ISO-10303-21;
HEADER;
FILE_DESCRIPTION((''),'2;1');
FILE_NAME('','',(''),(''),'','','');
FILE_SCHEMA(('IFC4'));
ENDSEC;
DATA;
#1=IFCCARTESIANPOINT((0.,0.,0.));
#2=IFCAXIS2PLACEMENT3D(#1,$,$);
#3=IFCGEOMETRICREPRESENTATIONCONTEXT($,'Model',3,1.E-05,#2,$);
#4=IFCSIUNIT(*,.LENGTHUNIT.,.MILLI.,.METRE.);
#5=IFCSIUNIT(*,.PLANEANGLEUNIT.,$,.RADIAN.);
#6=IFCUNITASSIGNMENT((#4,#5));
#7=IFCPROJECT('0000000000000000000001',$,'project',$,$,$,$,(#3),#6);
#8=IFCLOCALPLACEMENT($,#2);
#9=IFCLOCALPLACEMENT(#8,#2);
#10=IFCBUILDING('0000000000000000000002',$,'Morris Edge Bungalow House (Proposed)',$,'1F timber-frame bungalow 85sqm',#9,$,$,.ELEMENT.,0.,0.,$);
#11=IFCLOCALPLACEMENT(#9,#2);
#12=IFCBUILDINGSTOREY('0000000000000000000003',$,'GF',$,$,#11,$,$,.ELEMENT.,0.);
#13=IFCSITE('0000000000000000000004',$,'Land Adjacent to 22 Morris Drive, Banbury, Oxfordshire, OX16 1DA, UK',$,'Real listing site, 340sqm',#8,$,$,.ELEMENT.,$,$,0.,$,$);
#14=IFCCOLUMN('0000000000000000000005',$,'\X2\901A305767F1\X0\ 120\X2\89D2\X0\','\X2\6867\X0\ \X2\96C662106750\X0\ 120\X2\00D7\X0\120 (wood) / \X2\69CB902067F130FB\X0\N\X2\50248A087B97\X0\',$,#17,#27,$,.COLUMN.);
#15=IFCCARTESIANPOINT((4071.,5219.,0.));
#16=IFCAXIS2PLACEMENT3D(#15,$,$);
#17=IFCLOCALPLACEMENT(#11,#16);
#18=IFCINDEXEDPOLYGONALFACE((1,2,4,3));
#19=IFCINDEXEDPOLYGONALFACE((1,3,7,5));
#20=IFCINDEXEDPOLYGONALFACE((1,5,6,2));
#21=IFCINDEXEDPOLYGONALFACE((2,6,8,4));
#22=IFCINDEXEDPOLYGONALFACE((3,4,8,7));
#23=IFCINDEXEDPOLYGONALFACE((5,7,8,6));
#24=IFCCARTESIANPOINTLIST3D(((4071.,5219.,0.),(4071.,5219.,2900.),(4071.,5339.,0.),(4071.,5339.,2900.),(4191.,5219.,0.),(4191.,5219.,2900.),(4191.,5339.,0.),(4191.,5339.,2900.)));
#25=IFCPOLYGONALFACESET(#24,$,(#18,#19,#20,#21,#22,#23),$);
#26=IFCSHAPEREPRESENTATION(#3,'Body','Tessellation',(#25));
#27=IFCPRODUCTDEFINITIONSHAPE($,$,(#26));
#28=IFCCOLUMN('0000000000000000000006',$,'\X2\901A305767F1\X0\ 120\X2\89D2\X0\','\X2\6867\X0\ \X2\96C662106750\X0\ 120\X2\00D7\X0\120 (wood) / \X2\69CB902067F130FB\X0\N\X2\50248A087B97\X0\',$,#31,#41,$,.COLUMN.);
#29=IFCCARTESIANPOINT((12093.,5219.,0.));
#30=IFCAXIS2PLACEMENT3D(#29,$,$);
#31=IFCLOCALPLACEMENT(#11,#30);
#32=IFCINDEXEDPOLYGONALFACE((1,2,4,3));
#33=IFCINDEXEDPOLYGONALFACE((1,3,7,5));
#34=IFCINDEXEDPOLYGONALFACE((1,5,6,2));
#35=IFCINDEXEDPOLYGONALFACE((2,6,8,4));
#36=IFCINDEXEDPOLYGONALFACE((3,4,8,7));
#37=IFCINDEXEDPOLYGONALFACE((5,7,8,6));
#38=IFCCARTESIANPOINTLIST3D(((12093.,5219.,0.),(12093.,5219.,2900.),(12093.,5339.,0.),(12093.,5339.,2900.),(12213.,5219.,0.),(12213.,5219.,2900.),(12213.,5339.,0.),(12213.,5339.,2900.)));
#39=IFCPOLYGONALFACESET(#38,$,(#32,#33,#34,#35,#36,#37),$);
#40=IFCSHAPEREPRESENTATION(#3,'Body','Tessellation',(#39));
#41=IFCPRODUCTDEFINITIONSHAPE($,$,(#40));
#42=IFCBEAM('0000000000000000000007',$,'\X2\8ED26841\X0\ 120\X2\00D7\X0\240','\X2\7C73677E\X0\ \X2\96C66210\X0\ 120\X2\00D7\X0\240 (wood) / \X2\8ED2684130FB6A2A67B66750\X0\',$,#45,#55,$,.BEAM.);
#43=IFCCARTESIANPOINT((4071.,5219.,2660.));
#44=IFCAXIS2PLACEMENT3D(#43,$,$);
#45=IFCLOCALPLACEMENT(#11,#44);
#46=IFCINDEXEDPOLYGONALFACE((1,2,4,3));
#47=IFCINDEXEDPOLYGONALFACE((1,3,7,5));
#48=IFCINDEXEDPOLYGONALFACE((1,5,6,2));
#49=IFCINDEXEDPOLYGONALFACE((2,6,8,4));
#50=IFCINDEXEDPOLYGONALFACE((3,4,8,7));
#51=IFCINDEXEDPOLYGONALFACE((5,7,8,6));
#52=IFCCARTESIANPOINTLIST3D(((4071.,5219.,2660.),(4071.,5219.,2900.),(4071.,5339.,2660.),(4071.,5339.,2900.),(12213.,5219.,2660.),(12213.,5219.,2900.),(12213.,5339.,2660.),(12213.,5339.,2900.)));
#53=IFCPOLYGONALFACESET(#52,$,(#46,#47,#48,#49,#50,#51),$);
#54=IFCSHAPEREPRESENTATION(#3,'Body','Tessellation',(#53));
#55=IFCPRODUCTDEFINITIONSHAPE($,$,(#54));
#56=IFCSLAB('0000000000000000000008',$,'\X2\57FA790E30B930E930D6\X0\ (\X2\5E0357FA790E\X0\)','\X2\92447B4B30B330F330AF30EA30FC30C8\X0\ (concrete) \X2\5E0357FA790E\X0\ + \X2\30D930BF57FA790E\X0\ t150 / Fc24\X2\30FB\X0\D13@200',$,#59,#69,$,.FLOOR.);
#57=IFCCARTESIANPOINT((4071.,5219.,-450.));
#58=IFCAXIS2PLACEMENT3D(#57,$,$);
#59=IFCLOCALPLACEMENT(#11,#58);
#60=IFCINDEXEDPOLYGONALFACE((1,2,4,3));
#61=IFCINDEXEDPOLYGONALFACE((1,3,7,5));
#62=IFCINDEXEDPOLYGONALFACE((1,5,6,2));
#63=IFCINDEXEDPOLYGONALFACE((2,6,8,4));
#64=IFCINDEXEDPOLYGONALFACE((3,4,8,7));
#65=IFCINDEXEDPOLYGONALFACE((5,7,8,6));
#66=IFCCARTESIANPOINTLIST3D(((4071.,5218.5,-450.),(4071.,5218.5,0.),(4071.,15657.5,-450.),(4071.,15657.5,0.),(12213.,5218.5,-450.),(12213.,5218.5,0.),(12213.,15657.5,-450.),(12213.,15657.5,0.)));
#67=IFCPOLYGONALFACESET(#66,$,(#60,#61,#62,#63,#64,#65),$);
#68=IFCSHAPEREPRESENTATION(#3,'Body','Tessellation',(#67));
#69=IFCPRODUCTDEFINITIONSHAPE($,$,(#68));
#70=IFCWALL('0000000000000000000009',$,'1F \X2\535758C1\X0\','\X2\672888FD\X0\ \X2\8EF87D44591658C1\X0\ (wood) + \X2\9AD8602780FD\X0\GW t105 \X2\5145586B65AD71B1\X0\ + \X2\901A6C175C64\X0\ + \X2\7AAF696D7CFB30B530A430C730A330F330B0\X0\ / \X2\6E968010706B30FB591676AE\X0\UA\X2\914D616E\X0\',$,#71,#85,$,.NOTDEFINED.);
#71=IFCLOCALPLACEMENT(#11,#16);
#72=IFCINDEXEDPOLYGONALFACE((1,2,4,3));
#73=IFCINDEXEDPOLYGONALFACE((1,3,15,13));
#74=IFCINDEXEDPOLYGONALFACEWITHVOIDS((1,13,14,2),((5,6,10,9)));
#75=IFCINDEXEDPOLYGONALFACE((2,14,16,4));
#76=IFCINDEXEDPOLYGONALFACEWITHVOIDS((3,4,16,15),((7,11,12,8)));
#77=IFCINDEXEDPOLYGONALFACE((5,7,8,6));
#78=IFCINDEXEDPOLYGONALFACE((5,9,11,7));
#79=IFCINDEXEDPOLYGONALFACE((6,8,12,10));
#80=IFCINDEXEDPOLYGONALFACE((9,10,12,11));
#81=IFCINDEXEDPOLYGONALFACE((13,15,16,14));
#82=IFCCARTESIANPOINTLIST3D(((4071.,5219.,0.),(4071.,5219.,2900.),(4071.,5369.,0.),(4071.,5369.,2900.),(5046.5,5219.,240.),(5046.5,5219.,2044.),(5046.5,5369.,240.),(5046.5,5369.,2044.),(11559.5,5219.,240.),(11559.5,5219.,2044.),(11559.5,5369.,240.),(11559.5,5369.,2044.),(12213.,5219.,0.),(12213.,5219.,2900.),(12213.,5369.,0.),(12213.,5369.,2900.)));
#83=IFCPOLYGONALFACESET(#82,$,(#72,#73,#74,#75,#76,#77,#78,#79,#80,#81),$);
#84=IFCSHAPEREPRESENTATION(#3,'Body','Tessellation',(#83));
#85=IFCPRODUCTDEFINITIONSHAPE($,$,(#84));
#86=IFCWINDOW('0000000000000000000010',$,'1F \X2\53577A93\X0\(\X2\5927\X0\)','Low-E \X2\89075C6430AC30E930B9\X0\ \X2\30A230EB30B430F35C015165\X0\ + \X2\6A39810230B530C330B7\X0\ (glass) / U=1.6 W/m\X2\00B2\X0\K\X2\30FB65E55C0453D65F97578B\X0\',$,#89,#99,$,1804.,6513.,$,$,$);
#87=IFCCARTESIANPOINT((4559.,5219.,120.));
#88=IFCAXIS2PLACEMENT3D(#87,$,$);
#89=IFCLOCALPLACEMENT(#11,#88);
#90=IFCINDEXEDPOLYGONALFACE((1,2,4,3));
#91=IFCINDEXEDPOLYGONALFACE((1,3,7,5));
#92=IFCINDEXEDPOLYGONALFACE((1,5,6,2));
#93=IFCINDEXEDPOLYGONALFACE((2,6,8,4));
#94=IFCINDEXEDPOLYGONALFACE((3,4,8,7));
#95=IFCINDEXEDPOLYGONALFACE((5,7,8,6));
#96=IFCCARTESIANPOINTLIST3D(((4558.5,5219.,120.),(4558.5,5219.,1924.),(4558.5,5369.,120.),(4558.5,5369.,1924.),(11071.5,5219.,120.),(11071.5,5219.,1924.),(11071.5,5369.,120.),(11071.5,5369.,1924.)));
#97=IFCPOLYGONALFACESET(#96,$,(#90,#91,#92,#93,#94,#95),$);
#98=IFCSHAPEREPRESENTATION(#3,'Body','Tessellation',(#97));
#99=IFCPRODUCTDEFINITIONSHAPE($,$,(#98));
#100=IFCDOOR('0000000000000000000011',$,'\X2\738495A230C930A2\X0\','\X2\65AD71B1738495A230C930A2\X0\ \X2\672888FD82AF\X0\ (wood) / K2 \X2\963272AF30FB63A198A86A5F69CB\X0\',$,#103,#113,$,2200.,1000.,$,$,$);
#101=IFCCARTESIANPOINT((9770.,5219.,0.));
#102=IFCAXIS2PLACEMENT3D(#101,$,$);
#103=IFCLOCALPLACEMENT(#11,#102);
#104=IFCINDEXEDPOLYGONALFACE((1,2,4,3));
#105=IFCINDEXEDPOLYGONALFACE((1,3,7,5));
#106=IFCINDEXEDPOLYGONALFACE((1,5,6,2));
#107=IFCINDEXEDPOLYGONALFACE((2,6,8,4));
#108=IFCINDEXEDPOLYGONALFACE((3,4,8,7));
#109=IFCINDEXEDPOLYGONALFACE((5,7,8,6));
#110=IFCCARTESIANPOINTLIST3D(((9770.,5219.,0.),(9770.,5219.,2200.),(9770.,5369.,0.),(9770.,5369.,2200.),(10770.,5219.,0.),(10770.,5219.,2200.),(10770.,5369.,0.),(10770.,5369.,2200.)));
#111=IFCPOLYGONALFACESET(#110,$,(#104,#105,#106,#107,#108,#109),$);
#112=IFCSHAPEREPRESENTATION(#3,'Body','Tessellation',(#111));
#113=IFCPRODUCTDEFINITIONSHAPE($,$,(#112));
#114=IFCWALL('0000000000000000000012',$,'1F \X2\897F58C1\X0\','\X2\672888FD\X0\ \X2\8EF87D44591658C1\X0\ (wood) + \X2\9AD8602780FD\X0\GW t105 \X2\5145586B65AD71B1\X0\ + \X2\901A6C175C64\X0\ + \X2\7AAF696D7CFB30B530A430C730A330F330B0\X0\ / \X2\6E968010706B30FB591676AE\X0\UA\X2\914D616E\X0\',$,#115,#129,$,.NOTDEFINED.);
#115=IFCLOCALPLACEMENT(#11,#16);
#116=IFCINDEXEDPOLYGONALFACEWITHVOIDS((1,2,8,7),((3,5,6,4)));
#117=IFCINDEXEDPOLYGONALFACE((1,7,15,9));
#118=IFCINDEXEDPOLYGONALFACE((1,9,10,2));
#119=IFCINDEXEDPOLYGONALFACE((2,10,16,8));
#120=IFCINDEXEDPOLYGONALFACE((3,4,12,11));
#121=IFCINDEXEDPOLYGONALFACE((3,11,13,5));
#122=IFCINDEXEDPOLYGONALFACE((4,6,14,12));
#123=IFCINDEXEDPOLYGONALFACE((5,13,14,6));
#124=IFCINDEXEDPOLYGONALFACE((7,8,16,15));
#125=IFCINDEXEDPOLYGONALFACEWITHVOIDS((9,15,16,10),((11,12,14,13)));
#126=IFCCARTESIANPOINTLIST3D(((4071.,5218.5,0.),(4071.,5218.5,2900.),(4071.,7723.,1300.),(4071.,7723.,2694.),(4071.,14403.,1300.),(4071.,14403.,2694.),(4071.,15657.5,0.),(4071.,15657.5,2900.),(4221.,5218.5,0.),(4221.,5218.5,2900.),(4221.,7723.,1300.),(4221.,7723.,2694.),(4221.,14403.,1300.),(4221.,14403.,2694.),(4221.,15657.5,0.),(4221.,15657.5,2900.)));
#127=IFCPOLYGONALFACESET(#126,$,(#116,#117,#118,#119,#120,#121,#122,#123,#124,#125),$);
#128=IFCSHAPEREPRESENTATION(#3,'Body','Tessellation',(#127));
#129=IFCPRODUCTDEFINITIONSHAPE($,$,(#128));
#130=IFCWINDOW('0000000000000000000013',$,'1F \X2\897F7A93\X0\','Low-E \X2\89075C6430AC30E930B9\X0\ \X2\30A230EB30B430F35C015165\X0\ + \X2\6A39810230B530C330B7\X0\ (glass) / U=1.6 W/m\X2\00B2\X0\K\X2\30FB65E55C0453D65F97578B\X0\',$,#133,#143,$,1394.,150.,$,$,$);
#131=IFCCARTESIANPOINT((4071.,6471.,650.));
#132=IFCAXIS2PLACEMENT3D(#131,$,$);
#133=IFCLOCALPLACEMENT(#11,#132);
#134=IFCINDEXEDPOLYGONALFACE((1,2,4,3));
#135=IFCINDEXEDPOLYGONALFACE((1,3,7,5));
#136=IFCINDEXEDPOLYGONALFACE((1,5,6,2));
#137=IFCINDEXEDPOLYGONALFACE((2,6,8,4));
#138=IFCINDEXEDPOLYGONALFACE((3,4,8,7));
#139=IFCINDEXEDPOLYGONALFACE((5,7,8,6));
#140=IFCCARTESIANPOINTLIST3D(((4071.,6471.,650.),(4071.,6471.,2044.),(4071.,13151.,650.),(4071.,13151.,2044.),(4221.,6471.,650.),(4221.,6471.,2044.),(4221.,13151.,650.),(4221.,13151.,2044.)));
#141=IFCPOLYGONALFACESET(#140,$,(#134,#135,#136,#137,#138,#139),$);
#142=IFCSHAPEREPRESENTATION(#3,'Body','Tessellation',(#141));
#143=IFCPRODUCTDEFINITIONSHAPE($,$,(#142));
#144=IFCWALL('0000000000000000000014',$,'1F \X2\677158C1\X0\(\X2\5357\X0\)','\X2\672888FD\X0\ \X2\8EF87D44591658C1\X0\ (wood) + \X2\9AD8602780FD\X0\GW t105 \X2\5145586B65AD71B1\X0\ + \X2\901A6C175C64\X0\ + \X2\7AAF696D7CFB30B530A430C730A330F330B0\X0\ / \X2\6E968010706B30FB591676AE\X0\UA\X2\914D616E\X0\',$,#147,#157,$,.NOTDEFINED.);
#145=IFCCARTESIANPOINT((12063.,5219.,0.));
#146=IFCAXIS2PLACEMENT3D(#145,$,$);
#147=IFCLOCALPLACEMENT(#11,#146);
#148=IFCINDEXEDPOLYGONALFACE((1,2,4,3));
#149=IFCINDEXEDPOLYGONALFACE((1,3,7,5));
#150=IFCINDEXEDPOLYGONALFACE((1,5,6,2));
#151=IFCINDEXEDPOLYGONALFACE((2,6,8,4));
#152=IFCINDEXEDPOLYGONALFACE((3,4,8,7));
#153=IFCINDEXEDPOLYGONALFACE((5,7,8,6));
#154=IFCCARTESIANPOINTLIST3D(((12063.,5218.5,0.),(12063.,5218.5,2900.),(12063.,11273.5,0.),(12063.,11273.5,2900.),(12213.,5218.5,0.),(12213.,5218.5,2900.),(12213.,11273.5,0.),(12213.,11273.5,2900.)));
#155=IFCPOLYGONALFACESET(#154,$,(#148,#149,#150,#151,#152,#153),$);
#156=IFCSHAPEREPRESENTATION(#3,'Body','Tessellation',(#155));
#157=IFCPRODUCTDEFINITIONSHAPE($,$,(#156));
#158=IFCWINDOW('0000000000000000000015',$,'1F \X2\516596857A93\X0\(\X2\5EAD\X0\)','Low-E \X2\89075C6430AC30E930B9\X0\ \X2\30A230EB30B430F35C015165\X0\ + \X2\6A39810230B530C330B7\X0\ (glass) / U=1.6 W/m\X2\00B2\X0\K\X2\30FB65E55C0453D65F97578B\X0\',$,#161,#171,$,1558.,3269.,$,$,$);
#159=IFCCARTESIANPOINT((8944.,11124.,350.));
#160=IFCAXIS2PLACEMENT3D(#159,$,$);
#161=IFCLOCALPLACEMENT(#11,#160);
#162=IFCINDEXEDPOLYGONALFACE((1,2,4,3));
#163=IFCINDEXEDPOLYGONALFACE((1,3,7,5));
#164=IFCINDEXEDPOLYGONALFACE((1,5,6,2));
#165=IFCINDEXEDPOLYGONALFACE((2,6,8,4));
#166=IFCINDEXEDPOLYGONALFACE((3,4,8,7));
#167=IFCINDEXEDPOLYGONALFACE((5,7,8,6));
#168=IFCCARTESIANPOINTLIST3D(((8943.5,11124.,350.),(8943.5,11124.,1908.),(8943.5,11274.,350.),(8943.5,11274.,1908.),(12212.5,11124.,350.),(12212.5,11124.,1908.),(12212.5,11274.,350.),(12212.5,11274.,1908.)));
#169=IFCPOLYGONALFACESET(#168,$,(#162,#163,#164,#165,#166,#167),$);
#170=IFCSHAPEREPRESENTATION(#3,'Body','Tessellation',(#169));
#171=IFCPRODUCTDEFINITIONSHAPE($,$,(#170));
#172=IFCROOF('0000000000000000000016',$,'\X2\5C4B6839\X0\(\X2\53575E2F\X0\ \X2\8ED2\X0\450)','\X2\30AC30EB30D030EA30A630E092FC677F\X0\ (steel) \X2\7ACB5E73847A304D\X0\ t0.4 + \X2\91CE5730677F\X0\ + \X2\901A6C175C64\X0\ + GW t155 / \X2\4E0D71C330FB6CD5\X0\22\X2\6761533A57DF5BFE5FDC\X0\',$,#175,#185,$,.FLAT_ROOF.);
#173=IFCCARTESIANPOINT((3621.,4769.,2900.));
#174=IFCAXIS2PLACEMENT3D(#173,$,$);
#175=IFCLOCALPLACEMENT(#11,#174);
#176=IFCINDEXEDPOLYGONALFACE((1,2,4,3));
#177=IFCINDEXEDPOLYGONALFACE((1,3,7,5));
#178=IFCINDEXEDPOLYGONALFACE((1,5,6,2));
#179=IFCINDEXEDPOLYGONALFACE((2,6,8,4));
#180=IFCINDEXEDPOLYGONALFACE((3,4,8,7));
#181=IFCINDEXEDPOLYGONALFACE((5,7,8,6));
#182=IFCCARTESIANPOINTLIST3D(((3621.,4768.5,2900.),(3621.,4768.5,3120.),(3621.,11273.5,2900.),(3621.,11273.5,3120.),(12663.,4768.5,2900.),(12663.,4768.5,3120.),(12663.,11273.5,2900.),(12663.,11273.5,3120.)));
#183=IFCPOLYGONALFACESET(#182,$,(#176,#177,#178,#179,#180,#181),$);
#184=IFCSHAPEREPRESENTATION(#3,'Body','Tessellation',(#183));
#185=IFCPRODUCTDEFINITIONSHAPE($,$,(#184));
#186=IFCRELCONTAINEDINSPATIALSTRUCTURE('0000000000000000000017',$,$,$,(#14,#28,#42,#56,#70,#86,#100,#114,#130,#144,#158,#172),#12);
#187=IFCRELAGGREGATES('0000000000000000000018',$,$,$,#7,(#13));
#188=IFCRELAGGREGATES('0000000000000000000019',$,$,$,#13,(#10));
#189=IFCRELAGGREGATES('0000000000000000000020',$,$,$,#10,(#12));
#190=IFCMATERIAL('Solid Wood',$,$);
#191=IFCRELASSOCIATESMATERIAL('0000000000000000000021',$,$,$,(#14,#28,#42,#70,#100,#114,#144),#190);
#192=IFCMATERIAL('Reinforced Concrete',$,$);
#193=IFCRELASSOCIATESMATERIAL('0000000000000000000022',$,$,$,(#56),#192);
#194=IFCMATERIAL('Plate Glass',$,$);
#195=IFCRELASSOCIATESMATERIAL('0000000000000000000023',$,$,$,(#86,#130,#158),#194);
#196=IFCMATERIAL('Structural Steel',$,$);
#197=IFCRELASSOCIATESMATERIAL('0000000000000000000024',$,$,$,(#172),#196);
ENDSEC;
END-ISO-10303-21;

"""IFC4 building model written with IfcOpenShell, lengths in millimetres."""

from ifc_helpers import new_model, si_unit, frame, frame_2d, origin, place, context, project, spatial, rectangle, extrude, material, element, fill, save


model = new_model("IFC4")

# Units and contexts
model_context = context("Model", 3, precision=1e-05, world=origin())
ifc_project = project(units=[si_unit("LENGTHUNIT", "METRE", prefix="MILLI"), si_unit("PLANEANGLEUNIT", "RADIAN")], contexts=[model_context])

# Site, building, storey
site_placement = place(None, origin())
site = spatial("IfcSite", under=ifc_project, at=site_placement, Name="Land Adjacent to 22 Morris Drive, Banbury, Oxfordshire, OX16 1DA, UK", ObjectType="Real listing site, 340sqm", CompositionType="ELEMENT", RefElevation=0.0)
building_placement = place(site_placement, origin())
building = spatial("IfcBuilding", under=site, at=building_placement, Name="Morris Edge Bungalow House (Proposed)", ObjectType="1F timber-frame bungalow 85sqm", CompositionType="ELEMENT", ElevationOfRefHeight=0.0, ElevationOfTerrain=0.0)
storey_placement = place(building_placement, origin())
storey = spatial("IfcBuildingStorey", under=building, at=storey_placement, Name="GF", CompositionType="ELEMENT", Elevation=0.0)

# Columns
ifc_material_1 = material(Name="Solid Wood")
column_1_placement = place(storey_placement, frame((4071.0, 5219.0, 0.0)))
element("IfcColumn", 1, at=column_1_placement, inside=storey, material=ifc_material_1, Name="通し柱 120角", Description="桧 集成材 120×120 (wood) / 構造柱・N値計算", PredefinedType="COLUMN", context=model_context, shape_type="SweptSolid", body=[
    extrude(rectangle(XDim=120.0, YDim=120.0, at=frame_2d((60.0, 60.0))), frame((4071.0, 5219.0, 0.0)), (0.0, 0.0, 1.0), 2900.0),
])
column_2_placement = place(storey_placement, frame((12093.0, 5219.0, 0.0)))
element("IfcColumn", 2, at=column_2_placement, inside=storey, material=ifc_material_1, Name="通し柱 120角", Description="桧 集成材 120×120 (wood) / 構造柱・N値計算", PredefinedType="COLUMN", context=model_context, shape_type="SweptSolid", body=[
    extrude(rectangle(XDim=120.0, YDim=120.0, at=frame_2d((60.0, 60.0))), frame((12093.0, 5219.0, 0.0)), (0.0, 0.0, 1.0), 2900.0),
])

# Beam
beam_1_placement = place(storey_placement, frame((4071.0, 5219.0, 2660.0)))
element("IfcBeam", 3, at=beam_1_placement, inside=storey, material=ifc_material_1, Name="軒桁 120×240", Description="米松 集成 120×240 (wood) / 軒桁・横架材", PredefinedType="BEAM", context=model_context, shape_type="SweptSolid", body=[
    extrude(rectangle(XDim=8142.0, YDim=120.0, at=frame_2d((4071.0, 60.0))), frame((4071.0, 5219.0, 2660.0)), (0.0, 0.0, 1.0), 240.0),
])

# Slab
ifc_material_2 = material(Name="Reinforced Concrete")
slab_1_placement = place(storey_placement, frame((4071.0, 5219.0, -450.0)))
element("IfcSlab", 4, at=slab_1_placement, inside=storey, material=ifc_material_2, Name="基礎スラブ (布基礎)", Description="鉄筋コンクリート (concrete) 布基礎 + ベタ基礎 t150 / Fc24・D13@200", PredefinedType="FLOOR", context=model_context, shape_type="SweptSolid", body=[
    extrude(rectangle(XDim=8142.0, YDim=10439.0, at=frame_2d((4071.0, 5219.0))), frame((4071.0, 5219.0, -450.0)), (0.0, 0.0, 1.0), 450.0),
])

# Wall, openings, window, door
wall_1_placement = place(storey_placement, frame((4071.0, 5219.0, 0.0)))
wall_1 = element("IfcWall", 5, at=wall_1_placement, inside=storey, material=ifc_material_1, Name="1F 南壁", Description="木製 軸組外壁 (wood) + 高性能GW t105 充填断熱 + 通気層 + 窯業系サイディング / 準耐火・外皮UA配慮", PredefinedType="NOTDEFINED", context=model_context, shape_type="SweptSolid", body=[
    extrude(rectangle(XDim=8142.0, YDim=150.0, at=frame_2d((4071.0, 75.0))), frame((4071.0, 5219.0, 0.0)), (0.0, 0.0, 1.0), 2900.0),
])
opening_1_placement = place(storey_placement, frame((4559.0, 5219.0, 120.0)))
opening_1 = element("IfcOpeningElement", 6, at=opening_1_placement, cuts=wall_1, PredefinedType="NOTDEFINED", context=model_context, shape_type="SweptSolid", body=[
    extrude(rectangle(XDim=6513.0, YDim=150.0, at=frame_2d((3256.0, 75.0))), frame((4559.0, 5219.0, 120.0)), (0.0, 0.0, 1.0), 1804.0),
])
opening_2_placement = place(storey_placement, frame((9770.0, 5219.0, 0.0)))
opening_2 = element("IfcOpeningElement", 7, at=opening_2_placement, cuts=wall_1, PredefinedType="NOTDEFINED", context=model_context, shape_type="SweptSolid", body=[
    extrude(rectangle(XDim=1000.0, YDim=150.0, at=frame_2d((500.0, 75.0))), frame((9770.0, 5219.0, 0.0)), (0.0, 0.0, 1.0), 2200.0),
])
ifc_material_3 = material(Name="Plate Glass")
window_1_placement = place(storey_placement, frame((4559.0, 5219.0, 120.0)))
window_1 = element("IfcWindow", 8, at=window_1_placement, inside=storey, material=ifc_material_3, Name="1F 南窓(大)", Description="Low-E 複層ガラス アルゴン封入 + 樹脂サッシ (glass) / U=1.6 W/m²K・日射取得型", OverallHeight=1804.0, OverallWidth=6513.0, context=model_context, shape_type="SweptSolid", body=[
    extrude(rectangle(XDim=6513.0, YDim=150.0, at=frame_2d((3256.0, 75.0))), frame((4559.0, 5219.0, 120.0)), (0.0, 0.0, 1.0), 1804.0),
])
fill(opening_1, window_1)
door_1_placement = place(storey_placement, frame((9770.0, 5219.0, 0.0)))
door_1 = element("IfcDoor", 9, at=door_1_placement, inside=storey, material=ifc_material_1, Name="玄関ドア", Description="断熱玄関ドア 木製芯 (wood) / K2 防犯・採風機構", OverallHeight=2200.0, OverallWidth=1000.0, context=model_context, shape_type="SweptSolid", body=[
    extrude(rectangle(XDim=1000.0, YDim=150.0, at=frame_2d((500.0, 75.0))), frame((9770.0, 5219.0, 0.0)), (0.0, 0.0, 1.0), 2200.0),
])
fill(opening_2, door_1)

# Walls, openings, windows
wall_2_placement = place(storey_placement, frame((4071.0, 5219.0, 0.0)))
wall_2 = element("IfcWall", 10, at=wall_2_placement, inside=storey, material=ifc_material_1, Name="1F 西壁", Description="木製 軸組外壁 (wood) + 高性能GW t105 充填断熱 + 通気層 + 窯業系サイディング / 準耐火・外皮UA配慮", PredefinedType="NOTDEFINED", context=model_context, shape_type="SweptSolid", body=[
    extrude(rectangle(XDim=150.0, YDim=10439.0, at=frame_2d((75.0, 5219.0))), frame((4071.0, 5219.0, 0.0)), (0.0, 0.0, 1.0), 2900.0),
])
opening_3_placement = place(storey_placement, frame((4071.0, 6471.0, 650.0)))
opening_3 = element("IfcOpeningElement", 11, at=opening_3_placement, cuts=wall_2, PredefinedType="NOTDEFINED", context=model_context, shape_type="SweptSolid", body=[
    extrude(rectangle(XDim=150.0, YDim=6680.0, at=frame_2d((75.0, 3340.0))), frame((4071.0, 6471.0, 650.0)), (0.0, 0.0, 1.0), 1394.0),
])
window_2_placement = place(storey_placement, frame((4071.0, 6471.0, 650.0)))
window_2 = element("IfcWindow", 12, at=window_2_placement, inside=storey, material=ifc_material_3, Name="1F 西窓", Description="Low-E 複層ガラス アルゴン封入 + 樹脂サッシ (glass) / U=1.6 W/m²K・日射取得型", OverallHeight=1394.0, OverallWidth=150.0, context=model_context, shape_type="SweptSolid", body=[
    extrude(rectangle(XDim=150.0, YDim=6680.0, at=frame_2d((75.0, 3340.0))), frame((4071.0, 6471.0, 650.0)), (0.0, 0.0, 1.0), 1394.0),
])
fill(opening_3, window_2)
wall_3_placement = place(storey_placement, frame((12063.0, 5219.0, 0.0)))
wall_3 = element("IfcWall", 13, at=wall_3_placement, inside=storey, material=ifc_material_1, Name="1F 東壁(南)", Description="木製 軸組外壁 (wood) + 高性能GW t105 充填断熱 + 通気層 + 窯業系サイディング / 準耐火・外皮UA配慮", PredefinedType="NOTDEFINED", context=model_context, shape_type="SweptSolid", body=[
    extrude(rectangle(XDim=150.0, YDim=6055.0, at=frame_2d((75.0, 3027.0))), frame((12063.0, 5219.0, 0.0)), (0.0, 0.0, 1.0), 2900.0),
])
opening_4_placement = place(storey_placement, frame((8944.0, 11124.0, 350.0)))
opening_4 = element("IfcOpeningElement", 14, at=opening_4_placement, cuts=wall_3, PredefinedType="NOTDEFINED", context=model_context, shape_type="SweptSolid", body=[
    extrude(rectangle(XDim=3269.0, YDim=150.0, at=frame_2d((1634.0, 75.0))), frame((8944.0, 11124.0, 350.0)), (0.0, 0.0, 1.0), 1558.0),
])
window_3_placement = place(storey_placement, frame((8944.0, 11124.0, 350.0)))
window_3 = element("IfcWindow", 15, at=window_3_placement, inside=storey, material=ifc_material_3, Name="1F 入隅窓(庭)", Description="Low-E 複層ガラス アルゴン封入 + 樹脂サッシ (glass) / U=1.6 W/m²K・日射取得型", OverallHeight=1558.0, OverallWidth=3269.0, context=model_context, shape_type="SweptSolid", body=[
    extrude(rectangle(XDim=3269.0, YDim=150.0, at=frame_2d((1634.0, 75.0))), frame((8944.0, 11124.0, 350.0)), (0.0, 0.0, 1.0), 1558.0),
])
fill(opening_4, window_3)

# Roof
ifc_material_4 = material(Name="Structural Steel")
roof_placement = place(storey_placement, frame((3621.0, 4769.0, 2900.0)))
element("IfcRoof", 16, at=roof_placement, inside=storey, material=ifc_material_4, Name="屋根(南帯 軒450)", Description="ガルバリウム鋼板 (steel) 立平葺き t0.4 + 野地板 + 通気層 + GW t155 / 不燃・法22条区域対応", PredefinedType="FLAT_ROOF", context=model_context, shape_type="SweptSolid", body=[
    extrude(rectangle(XDim=9042.0, YDim=6505.0, at=frame_2d((4521.0, 3252.0))), frame((3621.0, 4769.0, 2900.0)), (0.0, 0.0, 1.0), 220.0),
])

save(model, "model.ifc")
